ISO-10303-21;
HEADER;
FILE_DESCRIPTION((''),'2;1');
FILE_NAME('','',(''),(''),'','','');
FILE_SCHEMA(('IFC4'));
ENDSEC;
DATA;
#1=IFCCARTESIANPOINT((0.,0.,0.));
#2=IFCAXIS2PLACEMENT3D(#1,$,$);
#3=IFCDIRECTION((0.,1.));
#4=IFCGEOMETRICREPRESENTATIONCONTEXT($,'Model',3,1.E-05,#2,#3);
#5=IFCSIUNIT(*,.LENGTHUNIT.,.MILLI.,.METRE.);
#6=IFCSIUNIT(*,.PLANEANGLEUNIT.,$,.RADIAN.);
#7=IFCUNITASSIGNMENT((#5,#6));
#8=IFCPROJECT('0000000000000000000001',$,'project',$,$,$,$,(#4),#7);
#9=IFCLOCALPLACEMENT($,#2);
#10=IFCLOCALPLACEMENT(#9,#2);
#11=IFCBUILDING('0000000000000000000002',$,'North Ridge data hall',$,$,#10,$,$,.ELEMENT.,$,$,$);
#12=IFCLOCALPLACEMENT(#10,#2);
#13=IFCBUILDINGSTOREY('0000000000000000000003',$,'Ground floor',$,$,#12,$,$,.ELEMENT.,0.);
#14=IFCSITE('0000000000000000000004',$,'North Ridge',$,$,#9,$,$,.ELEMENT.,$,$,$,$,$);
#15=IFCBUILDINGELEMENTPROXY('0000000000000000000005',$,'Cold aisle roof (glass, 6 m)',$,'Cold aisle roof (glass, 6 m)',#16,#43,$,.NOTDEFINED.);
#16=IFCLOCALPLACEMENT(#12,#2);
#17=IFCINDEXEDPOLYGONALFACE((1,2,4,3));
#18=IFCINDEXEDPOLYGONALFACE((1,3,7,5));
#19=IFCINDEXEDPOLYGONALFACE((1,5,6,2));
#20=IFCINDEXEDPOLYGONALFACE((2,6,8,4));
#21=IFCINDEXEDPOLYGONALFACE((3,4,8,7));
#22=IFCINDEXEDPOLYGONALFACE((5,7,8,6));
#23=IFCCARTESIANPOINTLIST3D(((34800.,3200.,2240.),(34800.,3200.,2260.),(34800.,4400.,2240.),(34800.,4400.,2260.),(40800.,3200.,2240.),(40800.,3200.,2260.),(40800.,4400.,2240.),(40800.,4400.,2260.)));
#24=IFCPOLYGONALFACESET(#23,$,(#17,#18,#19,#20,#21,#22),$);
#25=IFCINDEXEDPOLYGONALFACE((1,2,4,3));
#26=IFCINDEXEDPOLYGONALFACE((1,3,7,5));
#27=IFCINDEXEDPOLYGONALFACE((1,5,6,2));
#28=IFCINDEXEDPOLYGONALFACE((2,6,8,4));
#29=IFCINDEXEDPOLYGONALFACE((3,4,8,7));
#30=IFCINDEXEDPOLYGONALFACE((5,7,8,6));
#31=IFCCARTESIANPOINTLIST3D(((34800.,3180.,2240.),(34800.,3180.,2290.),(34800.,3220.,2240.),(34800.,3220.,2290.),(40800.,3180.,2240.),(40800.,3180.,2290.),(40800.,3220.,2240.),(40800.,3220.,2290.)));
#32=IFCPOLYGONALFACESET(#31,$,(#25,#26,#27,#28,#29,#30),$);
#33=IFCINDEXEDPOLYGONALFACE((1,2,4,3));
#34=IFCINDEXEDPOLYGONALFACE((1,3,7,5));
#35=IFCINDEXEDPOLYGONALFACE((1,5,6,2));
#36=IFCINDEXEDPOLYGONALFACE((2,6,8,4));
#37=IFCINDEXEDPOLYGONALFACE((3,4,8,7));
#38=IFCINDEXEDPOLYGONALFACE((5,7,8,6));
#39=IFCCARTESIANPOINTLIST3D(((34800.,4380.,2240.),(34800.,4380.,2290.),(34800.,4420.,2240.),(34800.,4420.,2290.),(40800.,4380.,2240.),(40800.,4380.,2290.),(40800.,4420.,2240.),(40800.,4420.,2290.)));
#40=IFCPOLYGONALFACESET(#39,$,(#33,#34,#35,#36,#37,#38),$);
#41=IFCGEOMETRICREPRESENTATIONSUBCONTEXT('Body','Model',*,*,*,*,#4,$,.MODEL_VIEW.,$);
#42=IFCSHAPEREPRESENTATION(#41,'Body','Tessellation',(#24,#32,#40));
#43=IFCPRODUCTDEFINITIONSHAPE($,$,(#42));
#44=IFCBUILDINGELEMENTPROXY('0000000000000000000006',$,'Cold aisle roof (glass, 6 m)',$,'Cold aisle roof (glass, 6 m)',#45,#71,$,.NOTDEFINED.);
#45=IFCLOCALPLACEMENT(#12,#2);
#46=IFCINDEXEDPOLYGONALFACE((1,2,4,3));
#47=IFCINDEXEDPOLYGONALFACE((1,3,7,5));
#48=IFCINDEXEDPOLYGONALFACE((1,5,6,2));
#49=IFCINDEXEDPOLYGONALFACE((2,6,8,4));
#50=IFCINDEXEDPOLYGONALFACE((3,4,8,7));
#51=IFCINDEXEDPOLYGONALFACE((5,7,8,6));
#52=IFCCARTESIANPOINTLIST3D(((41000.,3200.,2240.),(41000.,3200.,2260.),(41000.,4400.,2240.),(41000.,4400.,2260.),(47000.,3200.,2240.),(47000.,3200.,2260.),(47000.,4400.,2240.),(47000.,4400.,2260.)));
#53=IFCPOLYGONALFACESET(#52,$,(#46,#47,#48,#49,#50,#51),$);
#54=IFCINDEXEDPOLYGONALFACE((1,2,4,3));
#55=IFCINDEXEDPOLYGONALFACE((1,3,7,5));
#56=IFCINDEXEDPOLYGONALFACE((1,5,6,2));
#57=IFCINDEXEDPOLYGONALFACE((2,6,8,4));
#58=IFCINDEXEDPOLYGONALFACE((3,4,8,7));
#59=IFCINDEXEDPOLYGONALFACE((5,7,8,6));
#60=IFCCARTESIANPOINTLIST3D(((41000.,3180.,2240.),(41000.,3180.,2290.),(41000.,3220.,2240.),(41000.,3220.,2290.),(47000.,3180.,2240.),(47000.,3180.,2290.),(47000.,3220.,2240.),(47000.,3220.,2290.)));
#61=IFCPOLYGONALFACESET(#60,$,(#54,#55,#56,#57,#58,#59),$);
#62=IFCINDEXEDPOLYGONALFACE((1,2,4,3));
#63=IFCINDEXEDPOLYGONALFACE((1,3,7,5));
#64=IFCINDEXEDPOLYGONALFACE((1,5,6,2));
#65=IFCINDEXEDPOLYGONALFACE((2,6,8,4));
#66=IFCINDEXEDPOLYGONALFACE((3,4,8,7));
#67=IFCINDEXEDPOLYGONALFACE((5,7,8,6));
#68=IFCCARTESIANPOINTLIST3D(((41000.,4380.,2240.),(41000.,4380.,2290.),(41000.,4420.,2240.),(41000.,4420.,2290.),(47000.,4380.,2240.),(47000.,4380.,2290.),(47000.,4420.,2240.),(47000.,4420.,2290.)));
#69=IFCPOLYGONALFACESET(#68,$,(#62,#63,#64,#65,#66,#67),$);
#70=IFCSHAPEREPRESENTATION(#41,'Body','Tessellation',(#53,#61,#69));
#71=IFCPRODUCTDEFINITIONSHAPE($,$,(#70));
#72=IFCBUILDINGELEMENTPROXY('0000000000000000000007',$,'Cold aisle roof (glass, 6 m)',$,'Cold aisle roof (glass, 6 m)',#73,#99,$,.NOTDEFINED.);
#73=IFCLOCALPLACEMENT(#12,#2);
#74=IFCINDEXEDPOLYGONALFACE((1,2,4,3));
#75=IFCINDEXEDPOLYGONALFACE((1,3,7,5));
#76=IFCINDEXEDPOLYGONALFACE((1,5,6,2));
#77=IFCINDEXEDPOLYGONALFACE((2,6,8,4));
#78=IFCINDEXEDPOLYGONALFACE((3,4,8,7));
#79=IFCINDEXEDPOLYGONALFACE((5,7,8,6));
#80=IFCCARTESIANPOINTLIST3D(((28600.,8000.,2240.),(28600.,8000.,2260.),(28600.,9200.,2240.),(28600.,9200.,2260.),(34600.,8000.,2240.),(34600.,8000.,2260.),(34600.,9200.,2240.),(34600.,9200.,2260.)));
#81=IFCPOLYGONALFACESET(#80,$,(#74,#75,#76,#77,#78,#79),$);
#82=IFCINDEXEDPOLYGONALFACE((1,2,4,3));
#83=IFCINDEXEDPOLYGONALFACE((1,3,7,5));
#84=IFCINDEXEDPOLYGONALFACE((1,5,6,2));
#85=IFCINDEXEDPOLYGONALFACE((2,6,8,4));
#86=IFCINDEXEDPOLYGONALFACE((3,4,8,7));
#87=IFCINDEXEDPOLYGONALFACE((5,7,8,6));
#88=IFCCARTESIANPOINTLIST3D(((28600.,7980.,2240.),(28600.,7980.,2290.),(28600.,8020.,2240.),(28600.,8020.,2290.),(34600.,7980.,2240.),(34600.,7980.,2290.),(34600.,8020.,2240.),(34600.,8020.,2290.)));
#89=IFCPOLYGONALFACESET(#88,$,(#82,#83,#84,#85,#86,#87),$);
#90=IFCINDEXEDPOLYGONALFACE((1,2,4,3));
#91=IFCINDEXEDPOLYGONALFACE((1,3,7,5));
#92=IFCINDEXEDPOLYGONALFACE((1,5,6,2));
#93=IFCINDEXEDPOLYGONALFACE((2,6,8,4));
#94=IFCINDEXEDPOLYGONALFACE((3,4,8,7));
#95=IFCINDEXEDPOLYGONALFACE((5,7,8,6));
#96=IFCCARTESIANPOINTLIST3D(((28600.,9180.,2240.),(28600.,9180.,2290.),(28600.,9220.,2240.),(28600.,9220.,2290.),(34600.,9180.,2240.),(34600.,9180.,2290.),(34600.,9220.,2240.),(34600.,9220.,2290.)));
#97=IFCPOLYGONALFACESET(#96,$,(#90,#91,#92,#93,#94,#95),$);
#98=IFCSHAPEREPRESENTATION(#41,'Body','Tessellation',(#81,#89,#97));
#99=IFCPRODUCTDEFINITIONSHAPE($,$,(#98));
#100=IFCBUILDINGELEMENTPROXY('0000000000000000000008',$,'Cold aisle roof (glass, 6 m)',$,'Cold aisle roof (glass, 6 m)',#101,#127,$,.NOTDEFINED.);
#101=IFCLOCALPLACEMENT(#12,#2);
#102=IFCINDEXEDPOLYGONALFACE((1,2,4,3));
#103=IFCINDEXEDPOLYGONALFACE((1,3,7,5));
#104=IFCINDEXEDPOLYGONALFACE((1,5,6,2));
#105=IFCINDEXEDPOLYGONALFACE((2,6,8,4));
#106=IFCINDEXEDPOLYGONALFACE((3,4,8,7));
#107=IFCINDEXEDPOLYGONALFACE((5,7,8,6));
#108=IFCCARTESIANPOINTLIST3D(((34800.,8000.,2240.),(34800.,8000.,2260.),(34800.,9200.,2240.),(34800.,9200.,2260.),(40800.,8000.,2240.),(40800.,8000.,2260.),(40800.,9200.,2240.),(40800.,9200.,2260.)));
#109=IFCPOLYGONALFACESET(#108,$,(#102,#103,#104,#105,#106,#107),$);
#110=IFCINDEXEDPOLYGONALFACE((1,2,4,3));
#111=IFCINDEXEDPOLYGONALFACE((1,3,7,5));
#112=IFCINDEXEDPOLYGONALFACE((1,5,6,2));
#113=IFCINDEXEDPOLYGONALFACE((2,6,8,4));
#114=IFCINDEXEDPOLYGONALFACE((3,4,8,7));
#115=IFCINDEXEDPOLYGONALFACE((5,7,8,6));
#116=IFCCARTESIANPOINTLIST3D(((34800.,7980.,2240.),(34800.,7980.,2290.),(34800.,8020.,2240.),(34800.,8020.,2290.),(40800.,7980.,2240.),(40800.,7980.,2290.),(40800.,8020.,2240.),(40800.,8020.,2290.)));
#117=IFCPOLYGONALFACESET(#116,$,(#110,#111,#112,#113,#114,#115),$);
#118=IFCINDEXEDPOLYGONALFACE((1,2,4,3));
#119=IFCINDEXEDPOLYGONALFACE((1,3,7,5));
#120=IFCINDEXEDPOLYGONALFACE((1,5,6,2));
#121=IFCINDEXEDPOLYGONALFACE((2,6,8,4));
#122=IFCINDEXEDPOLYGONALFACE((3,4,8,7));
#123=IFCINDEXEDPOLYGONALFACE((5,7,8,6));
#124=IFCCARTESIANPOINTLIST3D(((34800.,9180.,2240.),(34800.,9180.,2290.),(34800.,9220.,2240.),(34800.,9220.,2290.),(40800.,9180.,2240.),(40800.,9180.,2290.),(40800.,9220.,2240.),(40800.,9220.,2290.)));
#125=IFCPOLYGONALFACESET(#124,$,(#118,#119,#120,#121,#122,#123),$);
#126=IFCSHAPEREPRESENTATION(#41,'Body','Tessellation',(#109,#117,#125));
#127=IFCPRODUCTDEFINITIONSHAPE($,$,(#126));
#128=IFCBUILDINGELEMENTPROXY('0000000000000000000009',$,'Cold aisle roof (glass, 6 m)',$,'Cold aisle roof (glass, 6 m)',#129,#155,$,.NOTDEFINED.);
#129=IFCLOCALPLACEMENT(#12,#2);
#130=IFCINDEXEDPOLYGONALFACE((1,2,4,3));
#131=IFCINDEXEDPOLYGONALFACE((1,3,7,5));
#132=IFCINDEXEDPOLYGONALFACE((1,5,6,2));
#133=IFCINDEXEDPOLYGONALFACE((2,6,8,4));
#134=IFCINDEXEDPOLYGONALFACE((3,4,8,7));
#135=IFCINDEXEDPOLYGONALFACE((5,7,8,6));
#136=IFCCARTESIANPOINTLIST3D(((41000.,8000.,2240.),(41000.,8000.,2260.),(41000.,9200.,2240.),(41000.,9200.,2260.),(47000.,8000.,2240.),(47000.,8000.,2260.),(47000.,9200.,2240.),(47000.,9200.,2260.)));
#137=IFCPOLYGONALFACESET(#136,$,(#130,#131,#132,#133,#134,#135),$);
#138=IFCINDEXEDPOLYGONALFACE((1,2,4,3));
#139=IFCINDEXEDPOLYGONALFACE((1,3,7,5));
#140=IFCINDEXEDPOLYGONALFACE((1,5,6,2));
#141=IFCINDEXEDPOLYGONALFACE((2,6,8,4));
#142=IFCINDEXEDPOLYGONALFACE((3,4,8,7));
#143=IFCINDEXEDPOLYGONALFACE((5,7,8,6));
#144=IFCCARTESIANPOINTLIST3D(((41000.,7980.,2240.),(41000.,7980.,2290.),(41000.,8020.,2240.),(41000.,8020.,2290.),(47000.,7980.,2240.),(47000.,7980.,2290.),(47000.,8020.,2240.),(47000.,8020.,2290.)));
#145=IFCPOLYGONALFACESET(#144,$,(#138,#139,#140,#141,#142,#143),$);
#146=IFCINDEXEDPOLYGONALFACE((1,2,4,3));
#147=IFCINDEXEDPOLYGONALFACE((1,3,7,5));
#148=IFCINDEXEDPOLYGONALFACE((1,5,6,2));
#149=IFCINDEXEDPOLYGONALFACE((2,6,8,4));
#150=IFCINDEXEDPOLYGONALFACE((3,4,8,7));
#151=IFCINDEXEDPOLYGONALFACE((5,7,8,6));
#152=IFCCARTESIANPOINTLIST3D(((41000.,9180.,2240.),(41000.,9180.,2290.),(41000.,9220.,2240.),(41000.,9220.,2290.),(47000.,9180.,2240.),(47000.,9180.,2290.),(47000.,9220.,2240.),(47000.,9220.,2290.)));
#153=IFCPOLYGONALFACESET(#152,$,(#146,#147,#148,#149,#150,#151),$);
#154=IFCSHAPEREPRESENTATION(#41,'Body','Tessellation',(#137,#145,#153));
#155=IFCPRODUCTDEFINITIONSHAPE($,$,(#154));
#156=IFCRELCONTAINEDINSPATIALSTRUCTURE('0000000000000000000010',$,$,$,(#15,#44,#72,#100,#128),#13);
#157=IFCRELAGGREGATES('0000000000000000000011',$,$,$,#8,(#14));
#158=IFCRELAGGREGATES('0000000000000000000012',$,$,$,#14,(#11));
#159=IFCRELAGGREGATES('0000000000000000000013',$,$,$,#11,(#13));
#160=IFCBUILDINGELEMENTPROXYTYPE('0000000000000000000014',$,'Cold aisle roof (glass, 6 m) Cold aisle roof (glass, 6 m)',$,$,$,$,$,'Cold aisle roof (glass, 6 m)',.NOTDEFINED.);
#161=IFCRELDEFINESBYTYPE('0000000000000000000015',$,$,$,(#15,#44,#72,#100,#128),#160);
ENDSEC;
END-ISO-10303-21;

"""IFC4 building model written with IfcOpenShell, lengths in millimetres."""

from ifc_helpers import new_model, si_unit, direction, frame, origin, place, context, subcontext, project, spatial, polyline, outline, extrude, source, transform, mapped, type_object, type_shapes, element, save


model = new_model("IFC4")

# Units and contexts
model_context = context("Model", 3, precision=1e-05, world=origin(), true_north=direction((0.0, 1.0)))
body_context = subcontext(model_context, "Body", "Model", "MODEL_VIEW")
ifc_project = project(units=[si_unit("LENGTHUNIT", "METRE", prefix="MILLI"), si_unit("PLANEANGLEUNIT", "RADIAN")], contexts=[model_context])

# Site, building, storey
site_placement = place(None, origin())
site = spatial("IfcSite", under=ifc_project, at=site_placement, Name="North Ridge", CompositionType="ELEMENT")
building_placement = place(site_placement, origin())
building = spatial("IfcBuilding", under=site, at=building_placement, Name="North Ridge data hall", CompositionType="ELEMENT")
storey_placement = place(building_placement, origin())
storey = spatial("IfcBuildingStorey", under=building, at=storey_placement, Name="Ground floor", CompositionType="ELEMENT", Elevation=0.0)

# Building element proxies
building_element_proxy_type_1 = type_object("IfcBuildingElementProxyType", Name="Cold aisle roof (glass, 6 m) Cold aisle roof (glass, 6 m)", ElementType="Cold aisle roof (glass, 6 m)", PredefinedType="NOTDEFINED")
shared_shape_1 = source(origin(), body_context, "Body", "SweptSolid", [
    extrude(outline(polyline([(0.0, 0.0), (6000.0, 0.0), (6000.0, 1200.0), (0.0, 1200.0), (0.0, 0.0)])), frame((0.0, 0.0, 2240.0)), (0.0, 0.0, 1.0), 20.0),
    extrude(outline(polyline([(0.0, -20.0), (6000.0, -20.0), (6000.0, 20.0), (0.0, 20.0), (0.0, -20.0)])), frame((0.0, 0.0, 2240.0)), (0.0, 0.0, 1.0), 50.0),
    extrude(outline(polyline([(0.0, 1180.0), (6000.0, 1180.0), (6000.0, 1220.0), (0.0, 1220.0), (0.0, 1180.0)])), frame((0.0, 0.0, 2240.0)), (0.0, 0.0, 1.0), 50.0),
])
type_shapes(building_element_proxy_type_1, [shared_shape_1])
for number, where, z_axis, x_axis, name in (
    (1, (34800.0, 3200.0, 0.0), (0.0, 0.0, 1.0), (1.0, 0.0, 0.0), "Cold aisle roof (glass, 6 m)"),
    (2, (41000.0, 3200.0, 0.0), (0.0, 0.0, 1.0), (1.0, 0.0, 0.0), "Cold aisle roof (glass, 6 m)"),
    (3, (28600.0, 8000.0, 0.0), (0.0, 0.0, 1.0), (1.0, 0.0, 0.0), "Cold aisle roof (glass, 6 m)"),
    (4, (34800.0, 8000.0, 0.0), (0.0, 0.0, 1.0), (1.0, 0.0, 0.0), "Cold aisle roof (glass, 6 m)"),
    (5, (41000.0, 8000.0, 0.0), (0.0, 0.0, 1.0), (1.0, 0.0, 0.0), "Cold aisle roof (glass, 6 m)"),
):
    element("IfcBuildingElementProxy", number, at=place(storey_placement, frame(where, z_axis=z_axis, x_axis=x_axis)), inside=storey, type_object=building_element_proxy_type_1, Name=name, ObjectType="Cold aisle roof (glass, 6 m)", PredefinedType="NOTDEFINED", context=body_context, shape_type="MappedRepresentation", body=[
        mapped(shared_shape_1, transform((0.0, 0.0, 0.0))),
    ])

save(model, "model.ifc")
